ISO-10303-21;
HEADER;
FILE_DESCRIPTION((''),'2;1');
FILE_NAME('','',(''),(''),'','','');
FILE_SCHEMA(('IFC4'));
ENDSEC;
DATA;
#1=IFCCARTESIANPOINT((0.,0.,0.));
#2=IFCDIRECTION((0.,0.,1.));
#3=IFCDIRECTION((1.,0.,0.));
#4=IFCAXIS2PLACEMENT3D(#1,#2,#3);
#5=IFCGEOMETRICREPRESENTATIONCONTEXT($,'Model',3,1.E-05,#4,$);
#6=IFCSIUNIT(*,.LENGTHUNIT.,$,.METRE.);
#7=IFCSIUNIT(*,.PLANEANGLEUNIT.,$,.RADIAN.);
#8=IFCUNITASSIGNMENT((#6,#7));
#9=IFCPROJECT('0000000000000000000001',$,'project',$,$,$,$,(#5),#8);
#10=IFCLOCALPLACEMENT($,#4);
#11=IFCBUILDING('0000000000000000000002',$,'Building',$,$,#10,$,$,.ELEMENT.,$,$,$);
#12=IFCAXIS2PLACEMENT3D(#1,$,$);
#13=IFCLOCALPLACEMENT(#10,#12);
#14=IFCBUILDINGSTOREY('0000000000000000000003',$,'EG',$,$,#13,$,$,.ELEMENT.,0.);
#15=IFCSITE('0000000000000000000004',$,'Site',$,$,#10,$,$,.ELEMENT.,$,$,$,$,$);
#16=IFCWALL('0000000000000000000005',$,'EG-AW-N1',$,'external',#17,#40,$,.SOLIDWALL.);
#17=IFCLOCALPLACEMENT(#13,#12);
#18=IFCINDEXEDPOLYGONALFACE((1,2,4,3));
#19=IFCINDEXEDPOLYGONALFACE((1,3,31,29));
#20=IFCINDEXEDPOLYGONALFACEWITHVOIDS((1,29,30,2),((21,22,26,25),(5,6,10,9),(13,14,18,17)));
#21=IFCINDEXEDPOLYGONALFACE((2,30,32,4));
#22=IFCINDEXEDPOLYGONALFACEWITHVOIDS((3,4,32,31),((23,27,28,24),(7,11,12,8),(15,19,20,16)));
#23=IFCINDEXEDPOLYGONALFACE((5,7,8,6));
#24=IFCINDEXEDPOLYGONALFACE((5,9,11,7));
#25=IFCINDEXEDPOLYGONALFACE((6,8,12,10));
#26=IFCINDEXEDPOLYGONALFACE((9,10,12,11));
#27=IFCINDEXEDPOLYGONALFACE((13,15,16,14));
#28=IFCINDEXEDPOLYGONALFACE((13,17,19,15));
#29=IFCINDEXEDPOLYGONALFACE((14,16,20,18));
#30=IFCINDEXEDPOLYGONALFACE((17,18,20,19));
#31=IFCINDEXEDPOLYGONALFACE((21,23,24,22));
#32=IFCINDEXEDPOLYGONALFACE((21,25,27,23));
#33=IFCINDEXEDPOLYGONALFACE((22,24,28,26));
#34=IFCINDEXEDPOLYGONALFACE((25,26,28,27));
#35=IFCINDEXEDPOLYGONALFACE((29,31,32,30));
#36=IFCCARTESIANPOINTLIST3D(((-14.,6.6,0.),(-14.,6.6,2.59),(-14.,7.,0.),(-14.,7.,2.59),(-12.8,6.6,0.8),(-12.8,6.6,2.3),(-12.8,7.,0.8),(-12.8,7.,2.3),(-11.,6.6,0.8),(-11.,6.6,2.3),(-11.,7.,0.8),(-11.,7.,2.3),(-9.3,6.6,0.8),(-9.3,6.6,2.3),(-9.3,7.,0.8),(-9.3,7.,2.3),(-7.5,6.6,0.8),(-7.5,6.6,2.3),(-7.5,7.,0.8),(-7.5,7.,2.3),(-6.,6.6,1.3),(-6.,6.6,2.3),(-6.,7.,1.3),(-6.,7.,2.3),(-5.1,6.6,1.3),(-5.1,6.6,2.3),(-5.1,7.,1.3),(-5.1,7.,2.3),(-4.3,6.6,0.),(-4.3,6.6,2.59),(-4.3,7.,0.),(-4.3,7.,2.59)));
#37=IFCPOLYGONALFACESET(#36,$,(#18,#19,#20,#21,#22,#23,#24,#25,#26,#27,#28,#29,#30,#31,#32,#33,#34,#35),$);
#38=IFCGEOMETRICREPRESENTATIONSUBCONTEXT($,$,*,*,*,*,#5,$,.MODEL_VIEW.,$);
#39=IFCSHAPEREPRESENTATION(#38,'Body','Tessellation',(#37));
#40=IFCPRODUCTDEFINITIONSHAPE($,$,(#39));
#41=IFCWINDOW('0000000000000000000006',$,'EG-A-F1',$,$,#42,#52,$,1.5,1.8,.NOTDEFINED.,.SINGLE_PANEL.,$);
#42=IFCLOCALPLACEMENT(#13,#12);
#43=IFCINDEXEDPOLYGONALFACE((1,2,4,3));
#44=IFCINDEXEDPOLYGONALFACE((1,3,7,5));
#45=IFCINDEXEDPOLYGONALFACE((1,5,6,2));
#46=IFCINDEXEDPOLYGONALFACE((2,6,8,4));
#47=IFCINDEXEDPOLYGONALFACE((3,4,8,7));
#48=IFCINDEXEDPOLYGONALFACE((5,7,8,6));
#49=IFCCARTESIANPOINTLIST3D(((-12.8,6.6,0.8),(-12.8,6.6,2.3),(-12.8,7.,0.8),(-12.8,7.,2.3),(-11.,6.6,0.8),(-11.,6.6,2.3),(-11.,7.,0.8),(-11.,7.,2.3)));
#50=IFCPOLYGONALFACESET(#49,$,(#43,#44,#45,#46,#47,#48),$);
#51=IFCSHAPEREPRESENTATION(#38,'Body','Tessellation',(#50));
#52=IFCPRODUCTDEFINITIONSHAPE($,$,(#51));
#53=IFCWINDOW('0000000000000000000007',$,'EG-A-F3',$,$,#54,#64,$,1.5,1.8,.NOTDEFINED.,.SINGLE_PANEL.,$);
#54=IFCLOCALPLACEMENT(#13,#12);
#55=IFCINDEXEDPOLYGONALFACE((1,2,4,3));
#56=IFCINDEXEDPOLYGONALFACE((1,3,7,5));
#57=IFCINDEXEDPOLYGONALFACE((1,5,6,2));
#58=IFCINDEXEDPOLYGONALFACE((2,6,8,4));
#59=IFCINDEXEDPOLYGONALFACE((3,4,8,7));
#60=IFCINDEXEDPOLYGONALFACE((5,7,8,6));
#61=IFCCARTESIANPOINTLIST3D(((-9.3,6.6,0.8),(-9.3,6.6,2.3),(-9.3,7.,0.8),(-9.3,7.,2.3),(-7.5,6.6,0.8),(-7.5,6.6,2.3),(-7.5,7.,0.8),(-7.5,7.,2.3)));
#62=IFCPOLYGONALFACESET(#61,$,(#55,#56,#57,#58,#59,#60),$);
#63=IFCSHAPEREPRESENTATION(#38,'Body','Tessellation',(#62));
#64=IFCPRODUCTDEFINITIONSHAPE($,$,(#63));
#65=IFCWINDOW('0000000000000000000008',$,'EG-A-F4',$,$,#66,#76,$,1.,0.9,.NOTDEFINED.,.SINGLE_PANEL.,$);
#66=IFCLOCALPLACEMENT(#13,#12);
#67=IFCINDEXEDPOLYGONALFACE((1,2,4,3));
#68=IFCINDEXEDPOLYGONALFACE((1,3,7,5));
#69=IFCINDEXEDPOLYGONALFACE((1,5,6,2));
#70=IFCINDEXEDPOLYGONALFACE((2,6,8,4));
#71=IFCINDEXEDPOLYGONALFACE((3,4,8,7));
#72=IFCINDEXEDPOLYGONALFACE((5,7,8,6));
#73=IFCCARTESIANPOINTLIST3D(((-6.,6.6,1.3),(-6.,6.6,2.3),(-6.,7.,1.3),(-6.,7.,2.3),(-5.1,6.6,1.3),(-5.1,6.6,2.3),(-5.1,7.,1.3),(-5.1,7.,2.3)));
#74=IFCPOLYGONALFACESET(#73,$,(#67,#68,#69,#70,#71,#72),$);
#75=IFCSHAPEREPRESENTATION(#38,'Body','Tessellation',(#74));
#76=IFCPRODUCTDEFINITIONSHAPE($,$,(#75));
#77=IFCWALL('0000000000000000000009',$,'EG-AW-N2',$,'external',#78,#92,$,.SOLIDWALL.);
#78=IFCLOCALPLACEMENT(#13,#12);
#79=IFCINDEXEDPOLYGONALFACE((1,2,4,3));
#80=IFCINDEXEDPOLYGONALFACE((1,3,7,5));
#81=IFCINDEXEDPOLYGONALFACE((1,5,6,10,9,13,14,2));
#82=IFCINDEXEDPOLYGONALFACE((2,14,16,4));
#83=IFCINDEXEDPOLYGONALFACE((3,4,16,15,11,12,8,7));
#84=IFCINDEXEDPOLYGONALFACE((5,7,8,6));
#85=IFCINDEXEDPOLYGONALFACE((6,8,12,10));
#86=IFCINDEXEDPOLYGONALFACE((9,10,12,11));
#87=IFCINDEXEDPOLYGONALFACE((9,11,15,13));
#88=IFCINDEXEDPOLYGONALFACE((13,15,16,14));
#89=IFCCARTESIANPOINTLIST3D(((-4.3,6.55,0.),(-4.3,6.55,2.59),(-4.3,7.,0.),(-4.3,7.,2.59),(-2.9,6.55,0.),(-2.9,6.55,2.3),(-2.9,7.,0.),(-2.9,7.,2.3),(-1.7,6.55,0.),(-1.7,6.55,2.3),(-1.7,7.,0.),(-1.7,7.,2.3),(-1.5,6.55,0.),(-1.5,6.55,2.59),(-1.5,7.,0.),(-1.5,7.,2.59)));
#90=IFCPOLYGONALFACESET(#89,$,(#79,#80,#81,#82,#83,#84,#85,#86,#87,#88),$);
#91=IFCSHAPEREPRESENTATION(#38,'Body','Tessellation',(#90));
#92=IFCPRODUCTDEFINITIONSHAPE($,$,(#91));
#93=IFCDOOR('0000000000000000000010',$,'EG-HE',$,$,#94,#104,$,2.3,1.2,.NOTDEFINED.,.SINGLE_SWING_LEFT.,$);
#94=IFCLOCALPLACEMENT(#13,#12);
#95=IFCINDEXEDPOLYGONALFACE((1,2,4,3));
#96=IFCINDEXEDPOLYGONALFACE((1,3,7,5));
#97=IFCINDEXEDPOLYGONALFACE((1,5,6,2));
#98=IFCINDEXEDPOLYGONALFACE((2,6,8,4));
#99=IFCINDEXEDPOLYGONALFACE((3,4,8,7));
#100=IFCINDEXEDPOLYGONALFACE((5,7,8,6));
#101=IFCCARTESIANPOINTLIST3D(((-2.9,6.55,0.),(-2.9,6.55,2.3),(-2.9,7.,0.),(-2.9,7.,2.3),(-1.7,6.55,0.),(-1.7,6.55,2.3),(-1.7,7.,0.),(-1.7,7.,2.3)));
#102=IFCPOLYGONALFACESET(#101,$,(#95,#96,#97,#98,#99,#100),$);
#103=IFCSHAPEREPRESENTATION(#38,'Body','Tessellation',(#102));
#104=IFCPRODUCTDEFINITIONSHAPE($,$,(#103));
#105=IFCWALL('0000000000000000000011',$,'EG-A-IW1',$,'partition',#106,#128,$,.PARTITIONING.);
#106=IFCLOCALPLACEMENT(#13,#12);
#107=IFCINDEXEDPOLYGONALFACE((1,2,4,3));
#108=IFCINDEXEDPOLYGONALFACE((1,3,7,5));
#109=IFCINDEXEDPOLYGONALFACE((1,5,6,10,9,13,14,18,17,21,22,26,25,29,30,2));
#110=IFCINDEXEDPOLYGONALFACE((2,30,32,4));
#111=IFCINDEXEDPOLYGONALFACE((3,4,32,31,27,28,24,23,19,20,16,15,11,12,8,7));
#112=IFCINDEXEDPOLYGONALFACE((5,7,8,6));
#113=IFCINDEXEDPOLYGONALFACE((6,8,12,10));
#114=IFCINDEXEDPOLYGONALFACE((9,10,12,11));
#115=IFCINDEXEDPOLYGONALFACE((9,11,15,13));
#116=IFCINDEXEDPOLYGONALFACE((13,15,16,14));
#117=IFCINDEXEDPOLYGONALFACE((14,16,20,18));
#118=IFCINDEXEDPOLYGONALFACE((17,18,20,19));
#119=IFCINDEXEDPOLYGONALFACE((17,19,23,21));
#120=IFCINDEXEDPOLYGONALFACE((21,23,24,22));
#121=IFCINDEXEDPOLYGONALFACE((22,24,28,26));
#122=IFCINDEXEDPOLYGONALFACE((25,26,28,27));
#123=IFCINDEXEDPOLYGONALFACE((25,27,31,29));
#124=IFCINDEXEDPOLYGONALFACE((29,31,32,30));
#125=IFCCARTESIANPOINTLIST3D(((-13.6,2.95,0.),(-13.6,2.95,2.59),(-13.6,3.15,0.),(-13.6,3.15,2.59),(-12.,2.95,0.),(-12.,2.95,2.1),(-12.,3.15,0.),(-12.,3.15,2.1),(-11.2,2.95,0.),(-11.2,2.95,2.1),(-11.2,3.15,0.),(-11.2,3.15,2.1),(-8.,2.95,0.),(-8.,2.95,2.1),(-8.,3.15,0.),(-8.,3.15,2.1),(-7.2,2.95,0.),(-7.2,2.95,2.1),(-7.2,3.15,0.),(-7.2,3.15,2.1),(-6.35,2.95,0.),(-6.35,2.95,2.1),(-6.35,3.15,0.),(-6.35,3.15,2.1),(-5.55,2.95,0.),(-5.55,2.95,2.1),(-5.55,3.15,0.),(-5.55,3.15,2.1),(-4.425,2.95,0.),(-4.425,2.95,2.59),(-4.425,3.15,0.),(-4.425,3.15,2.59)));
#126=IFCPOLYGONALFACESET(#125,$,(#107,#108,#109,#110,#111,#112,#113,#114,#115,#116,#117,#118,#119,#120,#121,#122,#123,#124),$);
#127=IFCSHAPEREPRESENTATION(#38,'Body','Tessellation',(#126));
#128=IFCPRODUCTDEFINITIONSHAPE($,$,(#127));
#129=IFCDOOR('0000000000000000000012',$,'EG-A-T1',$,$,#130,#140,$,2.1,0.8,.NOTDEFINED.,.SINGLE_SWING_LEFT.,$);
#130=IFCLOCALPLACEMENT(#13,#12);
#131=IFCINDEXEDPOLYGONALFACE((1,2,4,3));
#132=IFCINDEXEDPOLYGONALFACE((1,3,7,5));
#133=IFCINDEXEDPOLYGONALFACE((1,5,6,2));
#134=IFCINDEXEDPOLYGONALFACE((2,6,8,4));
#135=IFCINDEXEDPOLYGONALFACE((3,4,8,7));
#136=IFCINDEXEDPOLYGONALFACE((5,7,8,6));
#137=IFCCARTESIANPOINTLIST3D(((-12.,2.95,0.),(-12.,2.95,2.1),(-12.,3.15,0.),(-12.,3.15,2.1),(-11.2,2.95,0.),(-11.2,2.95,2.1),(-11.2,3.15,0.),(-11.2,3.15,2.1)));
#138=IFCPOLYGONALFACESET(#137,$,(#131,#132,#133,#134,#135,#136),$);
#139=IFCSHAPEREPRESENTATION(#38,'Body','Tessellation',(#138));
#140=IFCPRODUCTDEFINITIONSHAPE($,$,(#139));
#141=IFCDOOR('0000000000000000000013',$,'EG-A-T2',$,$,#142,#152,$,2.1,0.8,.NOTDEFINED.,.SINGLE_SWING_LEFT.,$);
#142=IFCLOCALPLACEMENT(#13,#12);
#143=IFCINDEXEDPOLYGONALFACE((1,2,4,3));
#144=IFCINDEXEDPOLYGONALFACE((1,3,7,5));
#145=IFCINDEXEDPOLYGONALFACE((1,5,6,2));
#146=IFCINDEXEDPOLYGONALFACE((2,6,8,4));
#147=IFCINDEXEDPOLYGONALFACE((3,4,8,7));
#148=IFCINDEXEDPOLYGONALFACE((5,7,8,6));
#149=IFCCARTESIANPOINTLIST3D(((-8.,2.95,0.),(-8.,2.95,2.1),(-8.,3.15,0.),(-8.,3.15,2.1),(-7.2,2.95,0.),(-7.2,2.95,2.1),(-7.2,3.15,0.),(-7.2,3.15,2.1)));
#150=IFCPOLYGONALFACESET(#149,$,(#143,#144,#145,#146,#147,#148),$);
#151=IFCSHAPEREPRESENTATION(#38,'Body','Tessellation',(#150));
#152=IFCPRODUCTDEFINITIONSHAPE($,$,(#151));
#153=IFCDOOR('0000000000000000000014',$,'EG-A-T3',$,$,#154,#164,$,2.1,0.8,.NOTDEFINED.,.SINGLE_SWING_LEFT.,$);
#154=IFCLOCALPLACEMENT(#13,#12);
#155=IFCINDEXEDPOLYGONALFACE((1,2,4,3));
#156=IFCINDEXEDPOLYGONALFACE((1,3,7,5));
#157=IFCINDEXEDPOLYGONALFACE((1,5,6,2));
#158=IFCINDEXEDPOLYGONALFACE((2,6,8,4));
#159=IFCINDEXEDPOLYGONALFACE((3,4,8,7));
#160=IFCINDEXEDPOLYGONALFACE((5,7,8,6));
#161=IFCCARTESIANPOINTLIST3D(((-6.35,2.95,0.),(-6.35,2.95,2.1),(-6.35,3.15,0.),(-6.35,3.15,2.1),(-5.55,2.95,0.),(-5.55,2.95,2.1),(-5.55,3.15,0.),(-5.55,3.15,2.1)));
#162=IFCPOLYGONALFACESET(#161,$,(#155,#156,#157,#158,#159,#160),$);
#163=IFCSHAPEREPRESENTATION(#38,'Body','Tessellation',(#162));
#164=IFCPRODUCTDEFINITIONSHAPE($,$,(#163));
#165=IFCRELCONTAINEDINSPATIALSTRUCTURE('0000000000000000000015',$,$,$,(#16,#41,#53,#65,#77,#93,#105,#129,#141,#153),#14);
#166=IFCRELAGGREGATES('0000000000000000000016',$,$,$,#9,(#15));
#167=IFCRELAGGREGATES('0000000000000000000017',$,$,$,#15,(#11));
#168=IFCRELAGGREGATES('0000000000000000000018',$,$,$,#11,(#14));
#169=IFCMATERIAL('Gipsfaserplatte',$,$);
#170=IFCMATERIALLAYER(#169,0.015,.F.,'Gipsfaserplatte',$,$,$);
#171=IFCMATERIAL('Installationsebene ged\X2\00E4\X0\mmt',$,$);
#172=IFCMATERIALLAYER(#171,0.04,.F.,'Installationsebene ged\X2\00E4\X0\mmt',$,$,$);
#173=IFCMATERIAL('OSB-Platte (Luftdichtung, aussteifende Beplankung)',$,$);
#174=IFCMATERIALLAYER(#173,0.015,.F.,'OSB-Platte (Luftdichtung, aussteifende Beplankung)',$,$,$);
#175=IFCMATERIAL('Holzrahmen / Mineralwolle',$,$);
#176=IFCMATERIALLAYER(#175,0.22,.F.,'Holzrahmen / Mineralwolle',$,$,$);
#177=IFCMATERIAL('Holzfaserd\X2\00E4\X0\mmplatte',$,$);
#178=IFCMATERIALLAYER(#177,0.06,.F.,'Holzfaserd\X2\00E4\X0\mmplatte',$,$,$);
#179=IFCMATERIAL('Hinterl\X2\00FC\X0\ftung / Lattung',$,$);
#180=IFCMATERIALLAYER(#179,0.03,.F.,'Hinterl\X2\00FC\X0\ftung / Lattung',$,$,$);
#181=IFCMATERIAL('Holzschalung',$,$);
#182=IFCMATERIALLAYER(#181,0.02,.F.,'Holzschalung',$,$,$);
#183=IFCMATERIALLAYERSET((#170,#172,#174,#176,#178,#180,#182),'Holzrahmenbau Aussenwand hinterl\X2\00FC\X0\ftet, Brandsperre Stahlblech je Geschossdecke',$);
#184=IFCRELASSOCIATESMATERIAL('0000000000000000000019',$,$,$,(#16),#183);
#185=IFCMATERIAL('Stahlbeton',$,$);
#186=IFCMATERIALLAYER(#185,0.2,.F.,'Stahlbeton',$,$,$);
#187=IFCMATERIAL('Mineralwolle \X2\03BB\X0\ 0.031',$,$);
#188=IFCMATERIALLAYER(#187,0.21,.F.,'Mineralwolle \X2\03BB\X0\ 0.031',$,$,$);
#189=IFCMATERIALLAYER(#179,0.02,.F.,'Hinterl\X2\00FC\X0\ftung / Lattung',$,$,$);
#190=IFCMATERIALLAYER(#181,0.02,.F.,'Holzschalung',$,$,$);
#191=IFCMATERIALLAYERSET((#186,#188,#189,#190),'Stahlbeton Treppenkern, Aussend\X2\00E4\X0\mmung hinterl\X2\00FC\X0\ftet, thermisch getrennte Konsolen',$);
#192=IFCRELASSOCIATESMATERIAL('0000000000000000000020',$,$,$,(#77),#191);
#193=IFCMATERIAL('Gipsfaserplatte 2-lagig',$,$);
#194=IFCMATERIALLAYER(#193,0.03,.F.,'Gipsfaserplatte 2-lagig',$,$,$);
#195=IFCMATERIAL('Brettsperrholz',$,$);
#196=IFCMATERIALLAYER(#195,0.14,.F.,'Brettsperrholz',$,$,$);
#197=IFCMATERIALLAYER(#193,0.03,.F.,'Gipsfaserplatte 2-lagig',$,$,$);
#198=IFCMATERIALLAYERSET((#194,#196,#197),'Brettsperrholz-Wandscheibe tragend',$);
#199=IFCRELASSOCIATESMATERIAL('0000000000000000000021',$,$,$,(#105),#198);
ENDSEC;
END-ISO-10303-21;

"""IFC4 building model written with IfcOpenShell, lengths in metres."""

from ifc_helpers import new_model, si_unit, frame, frame_2d, origin, origin_with_axes, place, context, subcontext, project, spatial, rectangle, extrude, material, layer, layer_set, element, fill, save


model = new_model("IFC4")

# Units and contexts
model_context = context("Model", 3, precision=1e-05, world=origin_with_axes())
sub_context = subcontext(model_context, None, None, "MODEL_VIEW")
ifc_project = project(units=[si_unit("LENGTHUNIT", "METRE"), si_unit("PLANEANGLEUNIT", "RADIAN")], contexts=[model_context])

# Site, building, storey
placement = place(None, origin_with_axes())
site = spatial("IfcSite", under=ifc_project, at=placement, Name="Site", CompositionType="ELEMENT")
building = spatial("IfcBuilding", under=site, at=placement, Name="Building", CompositionType="ELEMENT")
storey_placement = place(placement, origin())
storey = spatial("IfcBuildingStorey", under=building, at=storey_placement, Name="EG", CompositionType="ELEMENT", Elevation=0.0)

# Wall, openings, windows
ifc_material_1 = material(Name="Gipsfaserplatte")
ifc_layer_1 = layer(ifc_material_1, 0.015, ventilated=False, Name="Gipsfaserplatte")
ifc_material_2 = material(Name="Installationsebene gedämmt")
ifc_layer_2 = layer(ifc_material_2, 0.04, ventilated=False, Name="Installationsebene gedämmt")
ifc_material_3 = material(Name="OSB-Platte (Luftdichtung, aussteifende Beplankung)")
ifc_layer_3 = layer(ifc_material_3, 0.015, ventilated=False, Name="OSB-Platte (Luftdichtung, aussteifende Beplankung)")
ifc_material_4 = material(Name="Holzrahmen / Mineralwolle")
ifc_layer_4 = layer(ifc_material_4, 0.22, ventilated=False, Name="Holzrahmen / Mineralwolle")
ifc_material_5 = material(Name="Holzfaserdämmplatte")
ifc_layer_5 = layer(ifc_material_5, 0.06, ventilated=False, Name="Holzfaserdämmplatte")
ifc_material_6 = material(Name="Hinterlüftung / Lattung")
ifc_layer_6 = layer(ifc_material_6, 0.03, ventilated=False, Name="Hinterlüftung / Lattung")
ifc_material_7 = material(Name="Holzschalung")
ifc_layer_7 = layer(ifc_material_7, 0.02, ventilated=False, Name="Holzschalung")
ifc_layer_set_1 = layer_set([ifc_layer_1, ifc_layer_2, ifc_layer_3, ifc_layer_4, ifc_layer_5, ifc_layer_6, ifc_layer_7], Name="Holzrahmenbau Aussenwand hinterlüftet, Brandsperre Stahlblech je Geschossdecke")
wall_1_placement = place(storey_placement, frame((-14.0, 6.8, 0.0), z_axis=(0.0, 0.0, 1.0), x_axis=(1.0, 0.0, 0.0)))
wall_1 = element("IfcWall", 1, at=wall_1_placement, inside=storey, material=ifc_layer_set_1, Name="EG-AW-N1", ObjectType="external", PredefinedType="SOLIDWALL", context=sub_context, shape_type="SweptSolid", body=[
    extrude(rectangle(XDim=9.7, YDim=0.4, at=frame_2d((4.85, 0.0))), origin(), (0.0, 0.0, 1.0), 2.59),
])
opening_1_placement = place(wall_1_placement, frame((2.1, 0.25, 0.8), z_axis=(0.0, -1.0, 0.0), x_axis=(1.0, 0.0, 0.0)))
opening_1 = element("IfcOpeningElement", 2, at=opening_1_placement, cuts=wall_1, PredefinedType="OPENING", context=sub_context, shape_type="SweptSolid", body=[
    extrude(rectangle(XDim=1.8, YDim=1.5, at=frame_2d((0.0, 0.75))), origin(), (0.0, 0.0, 1.0), 0.5),
])
opening_2_placement = place(wall_1_placement, frame((5.6, 0.25, 0.8), z_axis=(0.0, -1.0, 0.0), x_axis=(1.0, 0.0, 0.0)))
opening_2 = element("IfcOpeningElement", 3, at=opening_2_placement, cuts=wall_1, PredefinedType="OPENING", context=sub_context, shape_type="SweptSolid", body=[
    extrude(rectangle(XDim=1.8, YDim=1.5, at=frame_2d((0.0, 0.75))), origin(), (0.0, 0.0, 1.0), 0.5),
])
opening_3_placement = place(wall_1_placement, frame((8.45, 0.25, 1.3), z_axis=(0.0, -1.0, 0.0), x_axis=(1.0, 0.0, 0.0)))
opening_3 = element("IfcOpeningElement", 4, at=opening_3_placement, cuts=wall_1, PredefinedType="OPENING", context=sub_context, shape_type="SweptSolid", body=[
    extrude(rectangle(XDim=0.9, YDim=1.0, at=frame_2d((0.0, 0.5))), origin(), (0.0, 0.0, 1.0), 0.5),
])
window_1_placement = place(wall_1_placement, frame((2.1, 0.2, 0.8), z_axis=(0.0, -1.0, 0.0), x_axis=(1.0, 0.0, 0.0)))
window_1 = element("IfcWindow", 5, at=window_1_placement, inside=storey, Name="EG-A-F1", OverallHeight=1.5, OverallWidth=1.8, PartitioningType="SINGLE_PANEL", PredefinedType="NOTDEFINED", context=sub_context, shape_type="SweptSolid", body=[
    extrude(rectangle(XDim=1.8, YDim=1.5, at=frame_2d((0.0, 0.75))), origin(), (0.0, 0.0, 1.0), 0.4),
])
fill(opening_1, window_1)
window_2_placement = place(wall_1_placement, frame((5.6, 0.2, 0.8), z_axis=(0.0, -1.0, 0.0), x_axis=(1.0, 0.0, 0.0)))
window_2 = element("IfcWindow", 6, at=window_2_placement, inside=storey, Name="EG-A-F3", OverallHeight=1.5, OverallWidth=1.8, PartitioningType="SINGLE_PANEL", PredefinedType="NOTDEFINED", context=sub_context, shape_type="SweptSolid", body=[
    extrude(rectangle(XDim=1.8, YDim=1.5, at=frame_2d((0.0, 0.75))), origin(), (0.0, 0.0, 1.0), 0.4),
])
fill(opening_2, window_2)
window_3_placement = place(wall_1_placement, frame((8.45, 0.2, 1.3), z_axis=(0.0, -1.0, 0.0), x_axis=(1.0, 0.0, 0.0)))
window_3 = element("IfcWindow", 7, at=window_3_placement, inside=storey, Name="EG-A-F4", OverallHeight=1.0, OverallWidth=0.9, PartitioningType="SINGLE_PANEL", PredefinedType="NOTDEFINED", context=sub_context, shape_type="SweptSolid", body=[
    extrude(rectangle(XDim=0.9, YDim=1.0, at=frame_2d((0.0, 0.5))), origin(), (0.0, 0.0, 1.0), 0.4),
])
fill(opening_3, window_3)

# Wall, opening, door
ifc_material_8 = material(Name="Stahlbeton")
ifc_layer_8 = layer(ifc_material_8, 0.2, ventilated=False, Name="Stahlbeton")
ifc_material_9 = material(Name="Mineralwolle λ 0.031")
ifc_layer_9 = layer(ifc_material_9, 0.21, ventilated=False, Name="Mineralwolle λ 0.031")
ifc_layer_10 = layer(ifc_material_6, 0.02, ventilated=False, Name="Hinterlüftung / Lattung")
ifc_layer_11 = layer(ifc_material_7, 0.02, ventilated=False, Name="Holzschalung")
ifc_layer_set_2 = layer_set([ifc_layer_8, ifc_layer_9, ifc_layer_10, ifc_layer_11], Name="Stahlbeton Treppenkern, Aussendämmung hinterlüftet, thermisch getrennte Konsolen")
wall_2_placement = place(storey_placement, frame((-4.3, 6.775, 0.0), z_axis=(0.0, 0.0, 1.0), x_axis=(1.0, 0.0, 0.0)))
wall_2 = element("IfcWall", 8, at=wall_2_placement, inside=storey, material=ifc_layer_set_2, Name="EG-AW-N2", ObjectType="external", PredefinedType="SOLIDWALL", context=sub_context, shape_type="SweptSolid", body=[
    extrude(rectangle(XDim=2.8, YDim=0.45, at=frame_2d((1.4, 0.0))), origin(), (0.0, 0.0, 1.0), 2.59),
])
opening_4_placement = place(wall_2_placement, frame((2.0, 0.275, 0.0), z_axis=(0.0, -1.0, 0.0), x_axis=(1.0, 0.0, 0.0)))
opening_4 = element("IfcOpeningElement", 9, at=opening_4_placement, cuts=wall_2, PredefinedType="OPENING", context=sub_context, shape_type="SweptSolid", body=[
    extrude(rectangle(XDim=1.2, YDim=2.3, at=frame_2d((0.0, 1.15))), origin(), (0.0, 0.0, 1.0), 0.55),
])
door_1_placement = place(wall_2_placement, frame((2.0, 0.225, 0.0), z_axis=(0.0, -1.0, 0.0), x_axis=(1.0, 0.0, 0.0)))
door_1 = element("IfcDoor", 10, at=door_1_placement, inside=storey, Name="EG-HE", OperationType="SINGLE_SWING_LEFT", OverallHeight=2.3, OverallWidth=1.2, PredefinedType="NOTDEFINED", context=sub_context, shape_type="SweptSolid", body=[
    extrude(rectangle(XDim=1.2, YDim=2.3, at=frame_2d((0.0, 1.15))), origin(), (0.0, 0.0, 1.0), 0.45),
])
fill(opening_4, door_1)

# Wall, openings, doors
ifc_material_10 = material(Name="Gipsfaserplatte 2-lagig")
ifc_layer_12 = layer(ifc_material_10, 0.03, ventilated=False, Name="Gipsfaserplatte 2-lagig")
ifc_material_11 = material(Name="Brettsperrholz")
ifc_layer_13 = layer(ifc_material_11, 0.14, ventilated=False, Name="Brettsperrholz")
ifc_layer_14 = layer(ifc_material_10, 0.03, ventilated=False, Name="Gipsfaserplatte 2-lagig")
ifc_layer_set_3 = layer_set([ifc_layer_12, ifc_layer_13, ifc_layer_14], Name="Brettsperrholz-Wandscheibe tragend")
wall_3_placement = place(storey_placement, frame((-13.6, 3.05, 0.0), z_axis=(0.0, 0.0, 1.0), x_axis=(1.0, 0.0, 0.0)))
wall_3 = element("IfcWall", 11, at=wall_3_placement, inside=storey, material=ifc_layer_set_3, Name="EG-A-IW1", ObjectType="partition", PredefinedType="PARTITIONING", context=sub_context, shape_type="SweptSolid", body=[
    extrude(rectangle(XDim=9.175, YDim=0.2, at=frame_2d((4.5875, 0.0))), origin(), (0.0, 0.0, 1.0), 2.59),
])
opening_5_placement = place(wall_3_placement, frame((2.0, 0.15, 0.0), z_axis=(0.0, -1.0, 0.0), x_axis=(1.0, 0.0, 0.0)))
opening_5 = element("IfcOpeningElement", 12, at=opening_5_placement, cuts=wall_3, PredefinedType="OPENING", context=sub_context, shape_type="SweptSolid", body=[
    extrude(rectangle(XDim=0.8, YDim=2.1, at=frame_2d((0.0, 1.05))), origin(), (0.0, 0.0, 1.0), 0.3),
])
opening_6_placement = place(wall_3_placement, frame((6.0, 0.15, 0.0), z_axis=(0.0, -1.0, 0.0), x_axis=(1.0, 0.0, 0.0)))
opening_6 = element("IfcOpeningElement", 13, at=opening_6_placement, cuts=wall_3, PredefinedType="OPENING", context=sub_context, shape_type="SweptSolid", body=[
    extrude(rectangle(XDim=0.8, YDim=2.1, at=frame_2d((0.0, 1.05))), origin(), (0.0, 0.0, 1.0), 0.3),
])
opening_7_placement = place(wall_3_placement, frame((7.65, 0.15, 0.0), z_axis=(0.0, -1.0, 0.0), x_axis=(1.0, 0.0, 0.0)))
opening_7 = element("IfcOpeningElement", 14, at=opening_7_placement, cuts=wall_3, PredefinedType="OPENING", context=sub_context, shape_type="SweptSolid", body=[
    extrude(rectangle(XDim=0.8, YDim=2.1, at=frame_2d((0.0, 1.05))), origin(), (0.0, 0.0, 1.0), 0.3),
])
door_2_placement = place(wall_3_placement, frame((2.0, 0.1, 0.0), z_axis=(0.0, -1.0, 0.0), x_axis=(1.0, 0.0, 0.0)))
door_2 = element("IfcDoor", 15, at=door_2_placement, inside=storey, Name="EG-A-T1", OperationType="SINGLE_SWING_LEFT", OverallHeight=2.1, OverallWidth=0.8, PredefinedType="NOTDEFINED", context=sub_context, shape_type="SweptSolid", body=[
    extrude(rectangle(XDim=0.8, YDim=2.1, at=frame_2d((0.0, 1.05))), origin(), (0.0, 0.0, 1.0), 0.2),
])
fill(opening_5, door_2)
door_3_placement = place(wall_3_placement, frame((6.0, 0.1, 0.0), z_axis=(0.0, -1.0, 0.0), x_axis=(1.0, 0.0, 0.0)))
door_3 = element("IfcDoor", 16, at=door_3_placement, inside=storey, Name="EG-A-T2", OperationType="SINGLE_SWING_LEFT", OverallHeight=2.1, OverallWidth=0.8, PredefinedType="NOTDEFINED", context=sub_context, shape_type="SweptSolid", body=[
    extrude(rectangle(XDim=0.8, YDim=2.1, at=frame_2d((0.0, 1.05))), origin(), (0.0, 0.0, 1.0), 0.2),
])
fill(opening_6, door_3)
door_4_placement = place(wall_3_placement, frame((7.65, 0.1, 0.0), z_axis=(0.0, -1.0, 0.0), x_axis=(1.0, 0.0, 0.0)))
door_4 = element("IfcDoor", 17, at=door_4_placement, inside=storey, Name="EG-A-T3", OperationType="SINGLE_SWING_LEFT", OverallHeight=2.1, OverallWidth=0.8, PredefinedType="NOTDEFINED", context=sub_context, shape_type="SweptSolid", body=[
    extrude(rectangle(XDim=0.8, YDim=2.1, at=frame_2d((0.0, 1.05))), origin(), (0.0, 0.0, 1.0), 0.2),
])
fill(opening_7, door_4)

save(model, "model.ifc")
